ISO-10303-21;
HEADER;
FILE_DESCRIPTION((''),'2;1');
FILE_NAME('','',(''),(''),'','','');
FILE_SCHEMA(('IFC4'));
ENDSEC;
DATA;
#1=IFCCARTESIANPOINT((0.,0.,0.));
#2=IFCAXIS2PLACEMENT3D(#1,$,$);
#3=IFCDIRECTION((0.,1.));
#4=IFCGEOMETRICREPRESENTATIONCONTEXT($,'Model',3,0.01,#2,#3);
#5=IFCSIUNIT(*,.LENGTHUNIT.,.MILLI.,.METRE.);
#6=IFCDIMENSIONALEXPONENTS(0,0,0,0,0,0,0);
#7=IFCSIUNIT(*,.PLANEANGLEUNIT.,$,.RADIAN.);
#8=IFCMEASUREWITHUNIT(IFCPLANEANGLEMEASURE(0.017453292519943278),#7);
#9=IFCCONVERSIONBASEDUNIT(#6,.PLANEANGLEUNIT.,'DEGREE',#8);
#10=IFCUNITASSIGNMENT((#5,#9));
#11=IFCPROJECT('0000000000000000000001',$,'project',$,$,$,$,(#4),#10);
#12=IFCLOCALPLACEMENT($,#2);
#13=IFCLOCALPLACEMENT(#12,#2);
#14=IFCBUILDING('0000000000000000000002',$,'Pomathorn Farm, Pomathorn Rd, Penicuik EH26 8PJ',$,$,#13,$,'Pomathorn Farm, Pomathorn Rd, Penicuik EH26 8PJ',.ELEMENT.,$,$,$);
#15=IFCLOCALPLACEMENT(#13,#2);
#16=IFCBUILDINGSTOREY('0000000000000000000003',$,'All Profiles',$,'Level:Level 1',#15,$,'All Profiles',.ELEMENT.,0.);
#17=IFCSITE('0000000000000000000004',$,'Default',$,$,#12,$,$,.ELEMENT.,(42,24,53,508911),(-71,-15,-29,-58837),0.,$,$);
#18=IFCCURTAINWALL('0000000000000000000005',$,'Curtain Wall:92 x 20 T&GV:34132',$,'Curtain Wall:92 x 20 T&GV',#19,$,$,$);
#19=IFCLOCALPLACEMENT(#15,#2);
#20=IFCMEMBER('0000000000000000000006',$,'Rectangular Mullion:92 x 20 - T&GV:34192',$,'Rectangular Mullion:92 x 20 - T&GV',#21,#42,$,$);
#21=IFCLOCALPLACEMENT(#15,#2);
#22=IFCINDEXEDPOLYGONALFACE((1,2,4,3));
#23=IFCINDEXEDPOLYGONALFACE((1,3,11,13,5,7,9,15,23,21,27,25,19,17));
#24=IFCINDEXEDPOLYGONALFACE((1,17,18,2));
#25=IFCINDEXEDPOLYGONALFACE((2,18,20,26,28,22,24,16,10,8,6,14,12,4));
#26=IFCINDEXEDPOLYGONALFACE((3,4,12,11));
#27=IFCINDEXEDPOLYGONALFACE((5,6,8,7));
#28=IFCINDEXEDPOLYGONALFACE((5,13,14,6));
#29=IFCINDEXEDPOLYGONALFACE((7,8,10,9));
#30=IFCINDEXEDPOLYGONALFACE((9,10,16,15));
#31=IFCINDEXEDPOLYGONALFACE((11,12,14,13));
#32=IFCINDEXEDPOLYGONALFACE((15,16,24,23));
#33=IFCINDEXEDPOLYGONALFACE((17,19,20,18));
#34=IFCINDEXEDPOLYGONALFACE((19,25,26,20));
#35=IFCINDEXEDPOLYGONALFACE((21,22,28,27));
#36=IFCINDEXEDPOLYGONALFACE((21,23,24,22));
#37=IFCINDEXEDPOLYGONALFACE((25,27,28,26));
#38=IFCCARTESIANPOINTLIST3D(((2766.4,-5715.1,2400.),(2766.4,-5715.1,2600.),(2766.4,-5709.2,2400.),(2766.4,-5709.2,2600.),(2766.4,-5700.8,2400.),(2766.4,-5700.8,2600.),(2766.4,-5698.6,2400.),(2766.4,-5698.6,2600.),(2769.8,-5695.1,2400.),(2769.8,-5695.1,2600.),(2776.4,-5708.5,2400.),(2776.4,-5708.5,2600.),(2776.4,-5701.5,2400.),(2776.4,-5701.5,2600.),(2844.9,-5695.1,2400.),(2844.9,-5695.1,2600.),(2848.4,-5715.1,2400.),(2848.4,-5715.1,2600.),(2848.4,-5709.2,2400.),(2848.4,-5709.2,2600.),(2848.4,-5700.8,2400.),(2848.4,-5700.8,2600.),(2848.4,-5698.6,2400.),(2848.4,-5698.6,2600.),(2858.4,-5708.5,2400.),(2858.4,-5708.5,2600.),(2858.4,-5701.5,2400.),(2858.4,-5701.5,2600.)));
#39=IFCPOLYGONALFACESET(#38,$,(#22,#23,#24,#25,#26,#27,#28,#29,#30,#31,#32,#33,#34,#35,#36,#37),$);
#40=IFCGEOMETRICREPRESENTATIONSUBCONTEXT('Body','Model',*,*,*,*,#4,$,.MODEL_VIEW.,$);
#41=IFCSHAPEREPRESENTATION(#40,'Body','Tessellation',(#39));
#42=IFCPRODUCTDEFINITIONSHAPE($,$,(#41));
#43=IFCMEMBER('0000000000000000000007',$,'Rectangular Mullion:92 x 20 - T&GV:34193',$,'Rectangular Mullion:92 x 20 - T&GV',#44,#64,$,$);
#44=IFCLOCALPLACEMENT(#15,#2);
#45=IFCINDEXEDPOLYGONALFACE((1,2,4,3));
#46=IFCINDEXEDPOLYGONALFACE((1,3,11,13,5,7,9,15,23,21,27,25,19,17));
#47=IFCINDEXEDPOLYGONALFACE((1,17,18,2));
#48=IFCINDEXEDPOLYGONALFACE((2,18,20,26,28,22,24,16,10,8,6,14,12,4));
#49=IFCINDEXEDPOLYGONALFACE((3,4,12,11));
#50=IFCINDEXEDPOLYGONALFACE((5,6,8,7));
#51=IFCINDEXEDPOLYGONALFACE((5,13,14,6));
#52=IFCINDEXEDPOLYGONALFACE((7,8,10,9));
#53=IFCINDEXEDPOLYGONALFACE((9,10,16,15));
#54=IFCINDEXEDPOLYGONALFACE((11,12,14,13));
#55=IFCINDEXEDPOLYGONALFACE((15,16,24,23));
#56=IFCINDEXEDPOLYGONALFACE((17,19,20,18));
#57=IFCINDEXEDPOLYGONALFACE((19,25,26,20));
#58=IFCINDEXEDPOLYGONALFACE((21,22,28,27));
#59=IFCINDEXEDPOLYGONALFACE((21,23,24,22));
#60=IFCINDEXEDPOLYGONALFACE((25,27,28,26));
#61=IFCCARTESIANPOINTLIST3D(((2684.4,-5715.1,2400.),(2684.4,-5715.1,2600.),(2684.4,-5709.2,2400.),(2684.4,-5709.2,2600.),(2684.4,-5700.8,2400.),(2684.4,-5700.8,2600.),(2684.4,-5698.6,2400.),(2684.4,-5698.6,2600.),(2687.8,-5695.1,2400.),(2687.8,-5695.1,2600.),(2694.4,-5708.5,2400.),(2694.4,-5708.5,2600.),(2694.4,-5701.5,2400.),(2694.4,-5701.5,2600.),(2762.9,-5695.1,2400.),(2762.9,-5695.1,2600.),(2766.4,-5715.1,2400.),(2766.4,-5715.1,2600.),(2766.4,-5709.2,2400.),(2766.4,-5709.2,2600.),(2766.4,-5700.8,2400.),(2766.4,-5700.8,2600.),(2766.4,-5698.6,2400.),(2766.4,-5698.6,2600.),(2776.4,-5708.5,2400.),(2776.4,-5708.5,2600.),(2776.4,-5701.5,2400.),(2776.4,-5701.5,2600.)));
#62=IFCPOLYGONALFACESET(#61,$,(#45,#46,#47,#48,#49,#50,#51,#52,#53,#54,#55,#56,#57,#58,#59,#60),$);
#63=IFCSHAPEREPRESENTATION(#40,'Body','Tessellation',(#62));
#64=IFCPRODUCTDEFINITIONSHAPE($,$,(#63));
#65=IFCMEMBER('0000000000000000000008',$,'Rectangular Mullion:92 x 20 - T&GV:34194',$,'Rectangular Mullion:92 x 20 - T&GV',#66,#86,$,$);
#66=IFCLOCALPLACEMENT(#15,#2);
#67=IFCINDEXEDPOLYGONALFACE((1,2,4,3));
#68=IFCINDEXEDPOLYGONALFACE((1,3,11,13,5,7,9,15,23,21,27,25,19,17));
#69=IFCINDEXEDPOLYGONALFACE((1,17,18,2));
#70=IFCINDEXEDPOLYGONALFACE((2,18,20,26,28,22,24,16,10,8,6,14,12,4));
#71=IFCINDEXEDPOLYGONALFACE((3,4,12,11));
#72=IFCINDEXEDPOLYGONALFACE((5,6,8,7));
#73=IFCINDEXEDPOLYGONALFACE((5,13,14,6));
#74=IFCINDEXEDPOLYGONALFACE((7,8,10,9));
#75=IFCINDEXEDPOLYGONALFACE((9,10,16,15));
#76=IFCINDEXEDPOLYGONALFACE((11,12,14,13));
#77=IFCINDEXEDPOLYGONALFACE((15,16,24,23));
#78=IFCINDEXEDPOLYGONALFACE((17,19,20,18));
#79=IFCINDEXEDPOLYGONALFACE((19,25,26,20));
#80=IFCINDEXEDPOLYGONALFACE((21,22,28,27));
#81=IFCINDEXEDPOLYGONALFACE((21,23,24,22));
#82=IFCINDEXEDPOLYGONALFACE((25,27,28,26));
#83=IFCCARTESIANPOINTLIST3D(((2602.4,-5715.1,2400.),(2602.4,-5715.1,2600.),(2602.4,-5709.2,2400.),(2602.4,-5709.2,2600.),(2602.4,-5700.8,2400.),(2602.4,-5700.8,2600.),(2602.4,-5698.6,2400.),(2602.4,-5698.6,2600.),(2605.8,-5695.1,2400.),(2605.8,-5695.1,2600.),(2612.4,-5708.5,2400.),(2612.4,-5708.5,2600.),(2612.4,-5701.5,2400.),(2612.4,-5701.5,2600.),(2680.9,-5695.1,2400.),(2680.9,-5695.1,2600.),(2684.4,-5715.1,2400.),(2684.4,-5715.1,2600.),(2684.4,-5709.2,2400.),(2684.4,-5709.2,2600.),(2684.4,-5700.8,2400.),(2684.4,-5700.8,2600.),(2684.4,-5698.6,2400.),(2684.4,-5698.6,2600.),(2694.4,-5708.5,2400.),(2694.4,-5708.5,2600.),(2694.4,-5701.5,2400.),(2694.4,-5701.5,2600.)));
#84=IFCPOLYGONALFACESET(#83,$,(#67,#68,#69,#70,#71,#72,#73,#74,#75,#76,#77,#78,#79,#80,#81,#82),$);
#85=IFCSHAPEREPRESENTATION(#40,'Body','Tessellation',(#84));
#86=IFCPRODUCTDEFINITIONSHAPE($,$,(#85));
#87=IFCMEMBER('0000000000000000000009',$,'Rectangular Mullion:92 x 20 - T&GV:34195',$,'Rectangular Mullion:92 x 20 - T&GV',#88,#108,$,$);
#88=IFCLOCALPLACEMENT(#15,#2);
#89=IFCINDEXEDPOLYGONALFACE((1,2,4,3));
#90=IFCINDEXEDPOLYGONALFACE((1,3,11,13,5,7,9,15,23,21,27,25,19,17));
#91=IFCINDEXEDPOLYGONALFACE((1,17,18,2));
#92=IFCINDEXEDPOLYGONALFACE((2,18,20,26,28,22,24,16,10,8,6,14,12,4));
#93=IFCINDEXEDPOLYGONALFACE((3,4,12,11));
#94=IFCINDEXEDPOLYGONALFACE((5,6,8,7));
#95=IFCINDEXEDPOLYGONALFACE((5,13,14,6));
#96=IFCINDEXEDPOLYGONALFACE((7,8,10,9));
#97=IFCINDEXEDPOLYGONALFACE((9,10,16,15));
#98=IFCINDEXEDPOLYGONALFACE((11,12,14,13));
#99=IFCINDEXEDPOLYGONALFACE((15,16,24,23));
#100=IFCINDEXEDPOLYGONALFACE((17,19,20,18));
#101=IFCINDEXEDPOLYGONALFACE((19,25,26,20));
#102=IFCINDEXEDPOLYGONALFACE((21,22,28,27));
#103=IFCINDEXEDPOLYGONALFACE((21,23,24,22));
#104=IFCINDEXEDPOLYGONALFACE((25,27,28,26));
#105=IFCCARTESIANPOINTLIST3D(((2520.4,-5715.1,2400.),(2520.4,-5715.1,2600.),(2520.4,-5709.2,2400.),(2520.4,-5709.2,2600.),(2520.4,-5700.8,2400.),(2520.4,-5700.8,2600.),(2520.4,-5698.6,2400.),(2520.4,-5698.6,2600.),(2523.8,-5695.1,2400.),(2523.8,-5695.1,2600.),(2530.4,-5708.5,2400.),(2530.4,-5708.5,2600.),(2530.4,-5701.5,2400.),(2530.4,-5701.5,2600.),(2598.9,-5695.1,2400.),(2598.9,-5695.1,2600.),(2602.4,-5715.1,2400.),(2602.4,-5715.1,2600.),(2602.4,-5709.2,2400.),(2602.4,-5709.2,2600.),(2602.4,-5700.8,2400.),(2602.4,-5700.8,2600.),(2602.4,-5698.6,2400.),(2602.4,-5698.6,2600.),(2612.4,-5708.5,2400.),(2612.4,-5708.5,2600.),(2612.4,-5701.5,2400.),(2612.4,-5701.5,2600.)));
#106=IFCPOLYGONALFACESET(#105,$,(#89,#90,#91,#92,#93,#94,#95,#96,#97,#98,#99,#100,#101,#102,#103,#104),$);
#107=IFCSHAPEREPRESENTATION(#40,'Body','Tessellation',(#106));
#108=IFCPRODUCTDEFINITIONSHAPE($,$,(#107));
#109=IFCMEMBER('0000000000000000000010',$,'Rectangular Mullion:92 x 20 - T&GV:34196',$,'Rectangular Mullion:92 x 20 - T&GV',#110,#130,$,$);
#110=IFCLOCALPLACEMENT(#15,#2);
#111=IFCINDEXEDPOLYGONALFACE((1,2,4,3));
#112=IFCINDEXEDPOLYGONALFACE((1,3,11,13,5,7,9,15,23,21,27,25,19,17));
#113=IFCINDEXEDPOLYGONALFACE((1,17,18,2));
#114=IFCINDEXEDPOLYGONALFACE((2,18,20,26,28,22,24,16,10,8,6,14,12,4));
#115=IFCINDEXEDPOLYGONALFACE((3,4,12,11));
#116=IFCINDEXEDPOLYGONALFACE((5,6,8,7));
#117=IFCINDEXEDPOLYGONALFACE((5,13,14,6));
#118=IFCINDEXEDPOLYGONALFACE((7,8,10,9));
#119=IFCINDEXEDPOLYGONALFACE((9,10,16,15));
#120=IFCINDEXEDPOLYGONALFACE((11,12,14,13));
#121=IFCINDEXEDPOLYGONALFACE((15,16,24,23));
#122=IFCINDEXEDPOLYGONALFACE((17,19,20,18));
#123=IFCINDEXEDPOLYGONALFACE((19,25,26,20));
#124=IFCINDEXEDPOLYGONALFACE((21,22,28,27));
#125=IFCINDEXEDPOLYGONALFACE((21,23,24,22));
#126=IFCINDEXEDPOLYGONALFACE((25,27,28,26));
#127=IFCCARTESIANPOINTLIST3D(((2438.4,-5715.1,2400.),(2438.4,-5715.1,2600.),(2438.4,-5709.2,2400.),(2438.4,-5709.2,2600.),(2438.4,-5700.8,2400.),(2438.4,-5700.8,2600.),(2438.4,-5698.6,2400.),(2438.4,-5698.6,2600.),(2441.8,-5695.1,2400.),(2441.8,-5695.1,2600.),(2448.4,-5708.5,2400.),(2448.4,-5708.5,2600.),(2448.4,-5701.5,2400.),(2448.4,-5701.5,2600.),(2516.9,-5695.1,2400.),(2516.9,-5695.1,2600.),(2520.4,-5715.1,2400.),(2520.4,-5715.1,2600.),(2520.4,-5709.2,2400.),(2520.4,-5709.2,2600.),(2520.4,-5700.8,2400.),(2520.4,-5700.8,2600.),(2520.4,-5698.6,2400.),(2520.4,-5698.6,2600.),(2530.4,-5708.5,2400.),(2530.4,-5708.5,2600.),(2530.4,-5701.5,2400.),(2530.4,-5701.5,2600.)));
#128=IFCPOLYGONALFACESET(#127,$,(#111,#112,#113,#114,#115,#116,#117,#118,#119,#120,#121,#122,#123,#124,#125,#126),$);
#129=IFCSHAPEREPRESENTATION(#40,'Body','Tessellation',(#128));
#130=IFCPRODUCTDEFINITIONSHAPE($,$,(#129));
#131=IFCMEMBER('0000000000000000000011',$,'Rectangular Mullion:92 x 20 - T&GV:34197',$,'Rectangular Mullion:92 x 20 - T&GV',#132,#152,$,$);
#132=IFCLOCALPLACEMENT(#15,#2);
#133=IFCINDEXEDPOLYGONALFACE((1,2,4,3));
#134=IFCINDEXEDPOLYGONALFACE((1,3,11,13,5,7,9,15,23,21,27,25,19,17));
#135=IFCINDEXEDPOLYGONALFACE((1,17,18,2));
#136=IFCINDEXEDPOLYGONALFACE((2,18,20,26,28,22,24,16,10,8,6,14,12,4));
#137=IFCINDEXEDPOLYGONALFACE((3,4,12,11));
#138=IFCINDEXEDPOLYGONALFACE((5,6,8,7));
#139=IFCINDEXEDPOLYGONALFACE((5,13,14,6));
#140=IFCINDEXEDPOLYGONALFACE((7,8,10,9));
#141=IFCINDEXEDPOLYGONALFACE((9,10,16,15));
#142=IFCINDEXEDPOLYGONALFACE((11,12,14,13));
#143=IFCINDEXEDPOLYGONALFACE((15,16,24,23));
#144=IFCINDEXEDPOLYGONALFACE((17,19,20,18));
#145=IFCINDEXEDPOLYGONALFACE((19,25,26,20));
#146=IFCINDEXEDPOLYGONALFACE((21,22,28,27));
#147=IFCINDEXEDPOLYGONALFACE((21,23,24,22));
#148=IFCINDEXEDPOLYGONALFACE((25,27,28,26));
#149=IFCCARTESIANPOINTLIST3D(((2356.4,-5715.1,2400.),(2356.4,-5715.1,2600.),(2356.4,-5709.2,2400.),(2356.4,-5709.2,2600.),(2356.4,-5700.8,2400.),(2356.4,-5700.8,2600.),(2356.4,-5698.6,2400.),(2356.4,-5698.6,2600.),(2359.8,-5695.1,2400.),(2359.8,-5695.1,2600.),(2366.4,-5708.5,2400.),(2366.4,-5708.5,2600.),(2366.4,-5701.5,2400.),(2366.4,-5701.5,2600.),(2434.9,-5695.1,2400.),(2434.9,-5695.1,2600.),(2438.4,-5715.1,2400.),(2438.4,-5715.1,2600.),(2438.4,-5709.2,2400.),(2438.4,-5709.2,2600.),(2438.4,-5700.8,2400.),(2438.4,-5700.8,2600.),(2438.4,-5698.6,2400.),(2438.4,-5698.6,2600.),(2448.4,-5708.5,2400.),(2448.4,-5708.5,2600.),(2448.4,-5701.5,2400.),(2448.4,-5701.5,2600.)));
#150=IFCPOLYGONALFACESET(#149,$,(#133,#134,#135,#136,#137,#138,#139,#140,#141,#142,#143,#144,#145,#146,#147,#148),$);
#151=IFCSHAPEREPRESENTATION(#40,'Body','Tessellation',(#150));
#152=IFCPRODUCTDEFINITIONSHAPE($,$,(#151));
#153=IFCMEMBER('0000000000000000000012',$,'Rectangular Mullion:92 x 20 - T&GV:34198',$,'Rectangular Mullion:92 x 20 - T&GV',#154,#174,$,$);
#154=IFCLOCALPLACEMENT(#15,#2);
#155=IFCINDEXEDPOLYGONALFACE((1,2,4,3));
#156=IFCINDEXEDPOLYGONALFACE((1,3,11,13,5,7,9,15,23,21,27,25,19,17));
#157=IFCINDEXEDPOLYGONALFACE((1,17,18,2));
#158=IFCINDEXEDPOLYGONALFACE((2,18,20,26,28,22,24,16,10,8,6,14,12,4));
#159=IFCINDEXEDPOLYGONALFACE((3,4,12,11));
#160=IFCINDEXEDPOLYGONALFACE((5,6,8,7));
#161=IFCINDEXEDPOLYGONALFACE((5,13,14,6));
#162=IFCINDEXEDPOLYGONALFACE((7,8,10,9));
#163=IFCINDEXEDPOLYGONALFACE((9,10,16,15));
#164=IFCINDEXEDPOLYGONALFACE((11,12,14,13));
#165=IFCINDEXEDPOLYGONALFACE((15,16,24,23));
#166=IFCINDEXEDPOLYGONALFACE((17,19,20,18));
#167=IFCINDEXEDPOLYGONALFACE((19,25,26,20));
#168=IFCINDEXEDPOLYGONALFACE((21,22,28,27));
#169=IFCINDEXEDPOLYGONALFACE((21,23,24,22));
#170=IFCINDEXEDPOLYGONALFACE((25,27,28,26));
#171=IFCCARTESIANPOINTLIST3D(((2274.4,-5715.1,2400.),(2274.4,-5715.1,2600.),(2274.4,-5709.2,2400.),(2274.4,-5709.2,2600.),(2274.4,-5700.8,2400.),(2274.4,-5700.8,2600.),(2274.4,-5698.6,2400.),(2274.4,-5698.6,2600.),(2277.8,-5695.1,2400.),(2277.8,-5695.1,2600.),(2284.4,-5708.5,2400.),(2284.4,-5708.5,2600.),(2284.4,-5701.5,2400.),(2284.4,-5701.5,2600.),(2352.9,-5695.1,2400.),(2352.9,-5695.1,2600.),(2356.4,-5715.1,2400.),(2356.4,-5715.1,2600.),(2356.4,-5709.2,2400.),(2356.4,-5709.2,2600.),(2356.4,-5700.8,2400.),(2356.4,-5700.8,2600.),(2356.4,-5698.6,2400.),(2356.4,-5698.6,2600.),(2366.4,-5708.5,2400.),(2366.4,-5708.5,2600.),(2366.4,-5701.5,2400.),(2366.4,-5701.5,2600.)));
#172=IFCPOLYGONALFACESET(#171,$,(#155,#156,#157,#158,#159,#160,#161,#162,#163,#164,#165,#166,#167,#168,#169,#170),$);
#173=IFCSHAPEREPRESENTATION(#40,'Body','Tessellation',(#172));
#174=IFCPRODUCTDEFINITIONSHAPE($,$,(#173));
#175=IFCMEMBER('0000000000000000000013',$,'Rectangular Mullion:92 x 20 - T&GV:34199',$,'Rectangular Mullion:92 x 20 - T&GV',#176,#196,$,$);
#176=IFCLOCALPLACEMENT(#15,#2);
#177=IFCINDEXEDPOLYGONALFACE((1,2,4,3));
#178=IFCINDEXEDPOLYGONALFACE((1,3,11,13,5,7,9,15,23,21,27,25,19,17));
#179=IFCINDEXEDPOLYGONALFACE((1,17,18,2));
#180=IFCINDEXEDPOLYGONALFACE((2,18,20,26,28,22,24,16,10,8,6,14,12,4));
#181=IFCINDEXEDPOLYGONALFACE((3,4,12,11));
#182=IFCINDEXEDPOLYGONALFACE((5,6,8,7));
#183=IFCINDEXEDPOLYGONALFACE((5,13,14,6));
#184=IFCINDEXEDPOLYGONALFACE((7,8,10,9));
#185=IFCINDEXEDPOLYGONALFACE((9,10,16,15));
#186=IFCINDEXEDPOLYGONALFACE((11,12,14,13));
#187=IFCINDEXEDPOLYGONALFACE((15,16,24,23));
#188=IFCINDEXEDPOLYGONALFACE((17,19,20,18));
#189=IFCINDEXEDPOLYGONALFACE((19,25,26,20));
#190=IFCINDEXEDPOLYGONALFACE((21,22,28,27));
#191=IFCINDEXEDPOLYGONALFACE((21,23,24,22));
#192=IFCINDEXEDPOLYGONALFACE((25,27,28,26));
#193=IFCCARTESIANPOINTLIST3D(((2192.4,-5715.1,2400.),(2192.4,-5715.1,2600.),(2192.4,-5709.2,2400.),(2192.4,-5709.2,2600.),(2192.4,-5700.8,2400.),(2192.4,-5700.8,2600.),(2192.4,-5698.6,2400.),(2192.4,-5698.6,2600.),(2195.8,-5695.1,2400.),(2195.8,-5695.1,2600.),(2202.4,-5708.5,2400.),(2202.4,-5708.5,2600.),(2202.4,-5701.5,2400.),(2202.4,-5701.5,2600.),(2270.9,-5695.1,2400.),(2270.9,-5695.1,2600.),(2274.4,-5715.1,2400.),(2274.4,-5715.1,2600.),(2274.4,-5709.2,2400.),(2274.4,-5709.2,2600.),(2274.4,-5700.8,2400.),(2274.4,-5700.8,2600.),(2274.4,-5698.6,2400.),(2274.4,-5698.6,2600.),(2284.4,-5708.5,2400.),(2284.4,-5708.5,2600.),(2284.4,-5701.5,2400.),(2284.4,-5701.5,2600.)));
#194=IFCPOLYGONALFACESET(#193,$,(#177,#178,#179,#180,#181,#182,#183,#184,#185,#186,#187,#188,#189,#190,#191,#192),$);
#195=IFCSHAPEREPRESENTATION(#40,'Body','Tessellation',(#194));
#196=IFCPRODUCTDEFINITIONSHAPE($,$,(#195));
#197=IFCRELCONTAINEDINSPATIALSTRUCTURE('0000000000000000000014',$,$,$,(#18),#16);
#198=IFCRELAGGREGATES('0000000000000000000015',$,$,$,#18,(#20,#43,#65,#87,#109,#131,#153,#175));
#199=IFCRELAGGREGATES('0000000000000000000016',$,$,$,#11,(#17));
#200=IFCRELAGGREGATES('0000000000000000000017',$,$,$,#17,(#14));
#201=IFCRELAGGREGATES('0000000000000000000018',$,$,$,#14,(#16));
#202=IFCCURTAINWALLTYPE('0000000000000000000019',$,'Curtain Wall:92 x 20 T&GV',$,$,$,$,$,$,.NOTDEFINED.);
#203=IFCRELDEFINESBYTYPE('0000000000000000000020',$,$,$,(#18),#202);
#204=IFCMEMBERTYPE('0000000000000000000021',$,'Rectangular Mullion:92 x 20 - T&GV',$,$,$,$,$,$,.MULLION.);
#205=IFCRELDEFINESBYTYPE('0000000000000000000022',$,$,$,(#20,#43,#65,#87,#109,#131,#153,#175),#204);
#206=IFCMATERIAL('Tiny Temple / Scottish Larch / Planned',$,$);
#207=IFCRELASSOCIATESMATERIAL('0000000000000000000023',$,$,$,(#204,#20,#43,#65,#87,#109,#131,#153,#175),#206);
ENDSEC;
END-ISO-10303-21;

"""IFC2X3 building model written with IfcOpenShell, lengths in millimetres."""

from ifc_helpers import new_model, entity, si_unit, converted_unit, direction, frame, origin, place, context, subcontext, project, spatial, polyline, outline, extrude, source, transform, mapped, material, type_object, type_shapes, element, aggregate, save


model = new_model("IFC2X3")

# Units and contexts
model_context = context("Model", 3, precision=0.01, world=origin(), true_north=direction((0.0, 1.0)))
body_context = subcontext(model_context, "Body", "Model", "MODEL_VIEW")
ifc_project = project(units=[si_unit("LENGTHUNIT", "METRE", prefix="MILLI"), converted_unit("PLANEANGLEUNIT", "DEGREE", entity("IfcPlaneAngleMeasure", 0.017453292519943278), si_unit("PLANEANGLEUNIT", "RADIAN"), dimensions=[0, 0, 0, 0, 0, 0, 0])], contexts=[model_context])

# Site, building, storey
site_placement = place(None, origin())
site = spatial("IfcSite", under=ifc_project, at=site_placement, Name="Default", CompositionType="ELEMENT", RefLatitude=(42, 24, 53, 508911), RefLongitude=(-71, -15, -29, -58837), RefElevation=0.0)
building_placement = place(site_placement, origin())
building = spatial("IfcBuilding", under=site, at=building_placement, Name="Pomathorn Farm, Pomathorn Rd, Penicuik EH26 8PJ", LongName="Pomathorn Farm, Pomathorn Rd, Penicuik EH26 8PJ", CompositionType="ELEMENT")
storey_placement = place(building_placement, origin())
storey = spatial("IfcBuildingStorey", under=building, at=storey_placement, Name="All Profiles", ObjectType="Level:Level 1", LongName="All Profiles", CompositionType="ELEMENT", Elevation=0.0)

# Shared definitions
ifc_material = material(Name="Tiny Temple / Scottish Larch / Planned")

# Curtain wall, members
curtain_wall_type_1 = type_object("IfcCurtainWallType", Name="Curtain Wall:92 x 20 T&GV", PredefinedType="NOTDEFINED")
curtain_wall_1_placement = place(storey_placement, origin())
curtain_wall_1 = element("IfcCurtainWall", 1, at=curtain_wall_1_placement, inside=storey, type_object=curtain_wall_type_1, Name="Curtain Wall:92 x 20 T&GV:34132", ObjectType="Curtain Wall:92 x 20 T&GV")
member_type_1 = type_object("IfcMemberType", Name="Rectangular Mullion:92 x 20 - T&GV", PredefinedType="MULLION", material=ifc_material)
shared_shape_1 = source(origin(), body_context, "Body", "SweptSolid", [
    extrude(outline(polyline([(-38.1, -11.0), (43.9, -11.0), (43.9, -5.1), (33.9, -4.4), (33.9, 2.6), (43.9, 3.3), (43.9, 5.5), (40.4, 9.0), (-34.7, 9.0), (-38.1, 5.5), (-38.1, 3.3), (-48.1, 2.6), (-48.1, -4.4), (-38.1, -5.1), (-38.1, -11.0)])), frame((-48.1, -11.0, -200.0), z_axis=(0.0, 0.0, 1.0), x_axis=(-1.0, 0.0, 0.0)), (0.0, 0.0, 1.0), 200.0),
])
type_shapes(member_type_1, [shared_shape_1])
member_1_placement = place(curtain_wall_1_placement, frame((2858.4, -5715.1, 2400.0), z_axis=(0.0, 0.0, -1.0), x_axis=(1.0, 0.0, 0.0)))
member_1 = element("IfcMember", 2, at=member_1_placement, type_object=member_type_1, material=ifc_material, Name="Rectangular Mullion:92 x 20 - T&GV:34192", ObjectType="Rectangular Mullion:92 x 20 - T&GV", context=body_context, shape_type="MappedRepresentation", body=[
    mapped(shared_shape_1, transform((0.0, 0.0, 0.0), scale=1.0)),
])
member_2_placement = place(curtain_wall_1_placement, frame((2776.4, -5715.1, 2400.0), z_axis=(0.0, 0.0, -1.0), x_axis=(1.0, 0.0, 0.0)))
member_2 = element("IfcMember", 3, at=member_2_placement, type_object=member_type_1, material=ifc_material, Name="Rectangular Mullion:92 x 20 - T&GV:34193", ObjectType="Rectangular Mullion:92 x 20 - T&GV", context=body_context, shape_type="MappedRepresentation", body=[
    mapped(shared_shape_1, transform((0.0, 0.0, 0.0), scale=1.0)),
])
member_3_placement = place(curtain_wall_1_placement, frame((2694.4, -5715.1, 2400.0), z_axis=(0.0, 0.0, -1.0), x_axis=(1.0, 0.0, 0.0)))
member_3 = element("IfcMember", 4, at=member_3_placement, type_object=member_type_1, material=ifc_material, Name="Rectangular Mullion:92 x 20 - T&GV:34194", ObjectType="Rectangular Mullion:92 x 20 - T&GV", context=body_context, shape_type="MappedRepresentation", body=[
    mapped(shared_shape_1, transform((0.0, 0.0, 0.0), scale=1.0)),
])
member_4_placement = place(curtain_wall_1_placement, frame((2612.4, -5715.1, 2400.0), z_axis=(0.0, 0.0, -1.0), x_axis=(1.0, 0.0, 0.0)))
member_4 = element("IfcMember", 5, at=member_4_placement, type_object=member_type_1, material=ifc_material, Name="Rectangular Mullion:92 x 20 - T&GV:34195", ObjectType="Rectangular Mullion:92 x 20 - T&GV", context=body_context, shape_type="MappedRepresentation", body=[
    mapped(shared_shape_1, transform((0.0, 0.0, 0.0), scale=1.0)),
])
member_5_placement = place(curtain_wall_1_placement, frame((2530.4, -5715.1, 2400.0), z_axis=(0.0, 0.0, -1.0), x_axis=(1.0, 0.0, 0.0)))
member_5 = element("IfcMember", 6, at=member_5_placement, type_object=member_type_1, material=ifc_material, Name="Rectangular Mullion:92 x 20 - T&GV:34196", ObjectType="Rectangular Mullion:92 x 20 - T&GV", context=body_context, shape_type="MappedRepresentation", body=[
    mapped(shared_shape_1, transform((0.0, 0.0, 0.0), scale=1.0)),
])
member_6_placement = place(curtain_wall_1_placement, frame((2448.4, -5715.1, 2400.0), z_axis=(0.0, 0.0, -1.0), x_axis=(1.0, 0.0, 0.0)))
member_6 = element("IfcMember", 7, at=member_6_placement, type_object=member_type_1, material=ifc_material, Name="Rectangular Mullion:92 x 20 - T&GV:34197", ObjectType="Rectangular Mullion:92 x 20 - T&GV", context=body_context, shape_type="MappedRepresentation", body=[
    mapped(shared_shape_1, transform((0.0, 0.0, 0.0), scale=1.0)),
])
member_7_placement = place(curtain_wall_1_placement, frame((2366.4, -5715.1, 2400.0), z_axis=(0.0, 0.0, -1.0), x_axis=(1.0, 0.0, 0.0)))
member_7 = element("IfcMember", 8, at=member_7_placement, type_object=member_type_1, material=ifc_material, Name="Rectangular Mullion:92 x 20 - T&GV:34198", ObjectType="Rectangular Mullion:92 x 20 - T&GV", context=body_context, shape_type="MappedRepresentation", body=[
    mapped(shared_shape_1, transform((0.0, 0.0, 0.0), scale=1.0)),
])
member_8_placement = place(curtain_wall_1_placement, frame((2284.4, -5715.1, 2400.0), z_axis=(0.0, 0.0, -1.0), x_axis=(1.0, 0.0, 0.0)))
member_8 = element("IfcMember", 9, at=member_8_placement, type_object=member_type_1, material=ifc_material, Name="Rectangular Mullion:92 x 20 - T&GV:34199", ObjectType="Rectangular Mullion:92 x 20 - T&GV", context=body_context, shape_type="MappedRepresentation", body=[
    mapped(shared_shape_1, transform((0.0, 0.0, 0.0), scale=1.0)),
])
aggregate(curtain_wall_1, [member_1, member_2, member_3, member_4, member_5, member_6, member_7, member_8])

save(model, "model.ifc")
